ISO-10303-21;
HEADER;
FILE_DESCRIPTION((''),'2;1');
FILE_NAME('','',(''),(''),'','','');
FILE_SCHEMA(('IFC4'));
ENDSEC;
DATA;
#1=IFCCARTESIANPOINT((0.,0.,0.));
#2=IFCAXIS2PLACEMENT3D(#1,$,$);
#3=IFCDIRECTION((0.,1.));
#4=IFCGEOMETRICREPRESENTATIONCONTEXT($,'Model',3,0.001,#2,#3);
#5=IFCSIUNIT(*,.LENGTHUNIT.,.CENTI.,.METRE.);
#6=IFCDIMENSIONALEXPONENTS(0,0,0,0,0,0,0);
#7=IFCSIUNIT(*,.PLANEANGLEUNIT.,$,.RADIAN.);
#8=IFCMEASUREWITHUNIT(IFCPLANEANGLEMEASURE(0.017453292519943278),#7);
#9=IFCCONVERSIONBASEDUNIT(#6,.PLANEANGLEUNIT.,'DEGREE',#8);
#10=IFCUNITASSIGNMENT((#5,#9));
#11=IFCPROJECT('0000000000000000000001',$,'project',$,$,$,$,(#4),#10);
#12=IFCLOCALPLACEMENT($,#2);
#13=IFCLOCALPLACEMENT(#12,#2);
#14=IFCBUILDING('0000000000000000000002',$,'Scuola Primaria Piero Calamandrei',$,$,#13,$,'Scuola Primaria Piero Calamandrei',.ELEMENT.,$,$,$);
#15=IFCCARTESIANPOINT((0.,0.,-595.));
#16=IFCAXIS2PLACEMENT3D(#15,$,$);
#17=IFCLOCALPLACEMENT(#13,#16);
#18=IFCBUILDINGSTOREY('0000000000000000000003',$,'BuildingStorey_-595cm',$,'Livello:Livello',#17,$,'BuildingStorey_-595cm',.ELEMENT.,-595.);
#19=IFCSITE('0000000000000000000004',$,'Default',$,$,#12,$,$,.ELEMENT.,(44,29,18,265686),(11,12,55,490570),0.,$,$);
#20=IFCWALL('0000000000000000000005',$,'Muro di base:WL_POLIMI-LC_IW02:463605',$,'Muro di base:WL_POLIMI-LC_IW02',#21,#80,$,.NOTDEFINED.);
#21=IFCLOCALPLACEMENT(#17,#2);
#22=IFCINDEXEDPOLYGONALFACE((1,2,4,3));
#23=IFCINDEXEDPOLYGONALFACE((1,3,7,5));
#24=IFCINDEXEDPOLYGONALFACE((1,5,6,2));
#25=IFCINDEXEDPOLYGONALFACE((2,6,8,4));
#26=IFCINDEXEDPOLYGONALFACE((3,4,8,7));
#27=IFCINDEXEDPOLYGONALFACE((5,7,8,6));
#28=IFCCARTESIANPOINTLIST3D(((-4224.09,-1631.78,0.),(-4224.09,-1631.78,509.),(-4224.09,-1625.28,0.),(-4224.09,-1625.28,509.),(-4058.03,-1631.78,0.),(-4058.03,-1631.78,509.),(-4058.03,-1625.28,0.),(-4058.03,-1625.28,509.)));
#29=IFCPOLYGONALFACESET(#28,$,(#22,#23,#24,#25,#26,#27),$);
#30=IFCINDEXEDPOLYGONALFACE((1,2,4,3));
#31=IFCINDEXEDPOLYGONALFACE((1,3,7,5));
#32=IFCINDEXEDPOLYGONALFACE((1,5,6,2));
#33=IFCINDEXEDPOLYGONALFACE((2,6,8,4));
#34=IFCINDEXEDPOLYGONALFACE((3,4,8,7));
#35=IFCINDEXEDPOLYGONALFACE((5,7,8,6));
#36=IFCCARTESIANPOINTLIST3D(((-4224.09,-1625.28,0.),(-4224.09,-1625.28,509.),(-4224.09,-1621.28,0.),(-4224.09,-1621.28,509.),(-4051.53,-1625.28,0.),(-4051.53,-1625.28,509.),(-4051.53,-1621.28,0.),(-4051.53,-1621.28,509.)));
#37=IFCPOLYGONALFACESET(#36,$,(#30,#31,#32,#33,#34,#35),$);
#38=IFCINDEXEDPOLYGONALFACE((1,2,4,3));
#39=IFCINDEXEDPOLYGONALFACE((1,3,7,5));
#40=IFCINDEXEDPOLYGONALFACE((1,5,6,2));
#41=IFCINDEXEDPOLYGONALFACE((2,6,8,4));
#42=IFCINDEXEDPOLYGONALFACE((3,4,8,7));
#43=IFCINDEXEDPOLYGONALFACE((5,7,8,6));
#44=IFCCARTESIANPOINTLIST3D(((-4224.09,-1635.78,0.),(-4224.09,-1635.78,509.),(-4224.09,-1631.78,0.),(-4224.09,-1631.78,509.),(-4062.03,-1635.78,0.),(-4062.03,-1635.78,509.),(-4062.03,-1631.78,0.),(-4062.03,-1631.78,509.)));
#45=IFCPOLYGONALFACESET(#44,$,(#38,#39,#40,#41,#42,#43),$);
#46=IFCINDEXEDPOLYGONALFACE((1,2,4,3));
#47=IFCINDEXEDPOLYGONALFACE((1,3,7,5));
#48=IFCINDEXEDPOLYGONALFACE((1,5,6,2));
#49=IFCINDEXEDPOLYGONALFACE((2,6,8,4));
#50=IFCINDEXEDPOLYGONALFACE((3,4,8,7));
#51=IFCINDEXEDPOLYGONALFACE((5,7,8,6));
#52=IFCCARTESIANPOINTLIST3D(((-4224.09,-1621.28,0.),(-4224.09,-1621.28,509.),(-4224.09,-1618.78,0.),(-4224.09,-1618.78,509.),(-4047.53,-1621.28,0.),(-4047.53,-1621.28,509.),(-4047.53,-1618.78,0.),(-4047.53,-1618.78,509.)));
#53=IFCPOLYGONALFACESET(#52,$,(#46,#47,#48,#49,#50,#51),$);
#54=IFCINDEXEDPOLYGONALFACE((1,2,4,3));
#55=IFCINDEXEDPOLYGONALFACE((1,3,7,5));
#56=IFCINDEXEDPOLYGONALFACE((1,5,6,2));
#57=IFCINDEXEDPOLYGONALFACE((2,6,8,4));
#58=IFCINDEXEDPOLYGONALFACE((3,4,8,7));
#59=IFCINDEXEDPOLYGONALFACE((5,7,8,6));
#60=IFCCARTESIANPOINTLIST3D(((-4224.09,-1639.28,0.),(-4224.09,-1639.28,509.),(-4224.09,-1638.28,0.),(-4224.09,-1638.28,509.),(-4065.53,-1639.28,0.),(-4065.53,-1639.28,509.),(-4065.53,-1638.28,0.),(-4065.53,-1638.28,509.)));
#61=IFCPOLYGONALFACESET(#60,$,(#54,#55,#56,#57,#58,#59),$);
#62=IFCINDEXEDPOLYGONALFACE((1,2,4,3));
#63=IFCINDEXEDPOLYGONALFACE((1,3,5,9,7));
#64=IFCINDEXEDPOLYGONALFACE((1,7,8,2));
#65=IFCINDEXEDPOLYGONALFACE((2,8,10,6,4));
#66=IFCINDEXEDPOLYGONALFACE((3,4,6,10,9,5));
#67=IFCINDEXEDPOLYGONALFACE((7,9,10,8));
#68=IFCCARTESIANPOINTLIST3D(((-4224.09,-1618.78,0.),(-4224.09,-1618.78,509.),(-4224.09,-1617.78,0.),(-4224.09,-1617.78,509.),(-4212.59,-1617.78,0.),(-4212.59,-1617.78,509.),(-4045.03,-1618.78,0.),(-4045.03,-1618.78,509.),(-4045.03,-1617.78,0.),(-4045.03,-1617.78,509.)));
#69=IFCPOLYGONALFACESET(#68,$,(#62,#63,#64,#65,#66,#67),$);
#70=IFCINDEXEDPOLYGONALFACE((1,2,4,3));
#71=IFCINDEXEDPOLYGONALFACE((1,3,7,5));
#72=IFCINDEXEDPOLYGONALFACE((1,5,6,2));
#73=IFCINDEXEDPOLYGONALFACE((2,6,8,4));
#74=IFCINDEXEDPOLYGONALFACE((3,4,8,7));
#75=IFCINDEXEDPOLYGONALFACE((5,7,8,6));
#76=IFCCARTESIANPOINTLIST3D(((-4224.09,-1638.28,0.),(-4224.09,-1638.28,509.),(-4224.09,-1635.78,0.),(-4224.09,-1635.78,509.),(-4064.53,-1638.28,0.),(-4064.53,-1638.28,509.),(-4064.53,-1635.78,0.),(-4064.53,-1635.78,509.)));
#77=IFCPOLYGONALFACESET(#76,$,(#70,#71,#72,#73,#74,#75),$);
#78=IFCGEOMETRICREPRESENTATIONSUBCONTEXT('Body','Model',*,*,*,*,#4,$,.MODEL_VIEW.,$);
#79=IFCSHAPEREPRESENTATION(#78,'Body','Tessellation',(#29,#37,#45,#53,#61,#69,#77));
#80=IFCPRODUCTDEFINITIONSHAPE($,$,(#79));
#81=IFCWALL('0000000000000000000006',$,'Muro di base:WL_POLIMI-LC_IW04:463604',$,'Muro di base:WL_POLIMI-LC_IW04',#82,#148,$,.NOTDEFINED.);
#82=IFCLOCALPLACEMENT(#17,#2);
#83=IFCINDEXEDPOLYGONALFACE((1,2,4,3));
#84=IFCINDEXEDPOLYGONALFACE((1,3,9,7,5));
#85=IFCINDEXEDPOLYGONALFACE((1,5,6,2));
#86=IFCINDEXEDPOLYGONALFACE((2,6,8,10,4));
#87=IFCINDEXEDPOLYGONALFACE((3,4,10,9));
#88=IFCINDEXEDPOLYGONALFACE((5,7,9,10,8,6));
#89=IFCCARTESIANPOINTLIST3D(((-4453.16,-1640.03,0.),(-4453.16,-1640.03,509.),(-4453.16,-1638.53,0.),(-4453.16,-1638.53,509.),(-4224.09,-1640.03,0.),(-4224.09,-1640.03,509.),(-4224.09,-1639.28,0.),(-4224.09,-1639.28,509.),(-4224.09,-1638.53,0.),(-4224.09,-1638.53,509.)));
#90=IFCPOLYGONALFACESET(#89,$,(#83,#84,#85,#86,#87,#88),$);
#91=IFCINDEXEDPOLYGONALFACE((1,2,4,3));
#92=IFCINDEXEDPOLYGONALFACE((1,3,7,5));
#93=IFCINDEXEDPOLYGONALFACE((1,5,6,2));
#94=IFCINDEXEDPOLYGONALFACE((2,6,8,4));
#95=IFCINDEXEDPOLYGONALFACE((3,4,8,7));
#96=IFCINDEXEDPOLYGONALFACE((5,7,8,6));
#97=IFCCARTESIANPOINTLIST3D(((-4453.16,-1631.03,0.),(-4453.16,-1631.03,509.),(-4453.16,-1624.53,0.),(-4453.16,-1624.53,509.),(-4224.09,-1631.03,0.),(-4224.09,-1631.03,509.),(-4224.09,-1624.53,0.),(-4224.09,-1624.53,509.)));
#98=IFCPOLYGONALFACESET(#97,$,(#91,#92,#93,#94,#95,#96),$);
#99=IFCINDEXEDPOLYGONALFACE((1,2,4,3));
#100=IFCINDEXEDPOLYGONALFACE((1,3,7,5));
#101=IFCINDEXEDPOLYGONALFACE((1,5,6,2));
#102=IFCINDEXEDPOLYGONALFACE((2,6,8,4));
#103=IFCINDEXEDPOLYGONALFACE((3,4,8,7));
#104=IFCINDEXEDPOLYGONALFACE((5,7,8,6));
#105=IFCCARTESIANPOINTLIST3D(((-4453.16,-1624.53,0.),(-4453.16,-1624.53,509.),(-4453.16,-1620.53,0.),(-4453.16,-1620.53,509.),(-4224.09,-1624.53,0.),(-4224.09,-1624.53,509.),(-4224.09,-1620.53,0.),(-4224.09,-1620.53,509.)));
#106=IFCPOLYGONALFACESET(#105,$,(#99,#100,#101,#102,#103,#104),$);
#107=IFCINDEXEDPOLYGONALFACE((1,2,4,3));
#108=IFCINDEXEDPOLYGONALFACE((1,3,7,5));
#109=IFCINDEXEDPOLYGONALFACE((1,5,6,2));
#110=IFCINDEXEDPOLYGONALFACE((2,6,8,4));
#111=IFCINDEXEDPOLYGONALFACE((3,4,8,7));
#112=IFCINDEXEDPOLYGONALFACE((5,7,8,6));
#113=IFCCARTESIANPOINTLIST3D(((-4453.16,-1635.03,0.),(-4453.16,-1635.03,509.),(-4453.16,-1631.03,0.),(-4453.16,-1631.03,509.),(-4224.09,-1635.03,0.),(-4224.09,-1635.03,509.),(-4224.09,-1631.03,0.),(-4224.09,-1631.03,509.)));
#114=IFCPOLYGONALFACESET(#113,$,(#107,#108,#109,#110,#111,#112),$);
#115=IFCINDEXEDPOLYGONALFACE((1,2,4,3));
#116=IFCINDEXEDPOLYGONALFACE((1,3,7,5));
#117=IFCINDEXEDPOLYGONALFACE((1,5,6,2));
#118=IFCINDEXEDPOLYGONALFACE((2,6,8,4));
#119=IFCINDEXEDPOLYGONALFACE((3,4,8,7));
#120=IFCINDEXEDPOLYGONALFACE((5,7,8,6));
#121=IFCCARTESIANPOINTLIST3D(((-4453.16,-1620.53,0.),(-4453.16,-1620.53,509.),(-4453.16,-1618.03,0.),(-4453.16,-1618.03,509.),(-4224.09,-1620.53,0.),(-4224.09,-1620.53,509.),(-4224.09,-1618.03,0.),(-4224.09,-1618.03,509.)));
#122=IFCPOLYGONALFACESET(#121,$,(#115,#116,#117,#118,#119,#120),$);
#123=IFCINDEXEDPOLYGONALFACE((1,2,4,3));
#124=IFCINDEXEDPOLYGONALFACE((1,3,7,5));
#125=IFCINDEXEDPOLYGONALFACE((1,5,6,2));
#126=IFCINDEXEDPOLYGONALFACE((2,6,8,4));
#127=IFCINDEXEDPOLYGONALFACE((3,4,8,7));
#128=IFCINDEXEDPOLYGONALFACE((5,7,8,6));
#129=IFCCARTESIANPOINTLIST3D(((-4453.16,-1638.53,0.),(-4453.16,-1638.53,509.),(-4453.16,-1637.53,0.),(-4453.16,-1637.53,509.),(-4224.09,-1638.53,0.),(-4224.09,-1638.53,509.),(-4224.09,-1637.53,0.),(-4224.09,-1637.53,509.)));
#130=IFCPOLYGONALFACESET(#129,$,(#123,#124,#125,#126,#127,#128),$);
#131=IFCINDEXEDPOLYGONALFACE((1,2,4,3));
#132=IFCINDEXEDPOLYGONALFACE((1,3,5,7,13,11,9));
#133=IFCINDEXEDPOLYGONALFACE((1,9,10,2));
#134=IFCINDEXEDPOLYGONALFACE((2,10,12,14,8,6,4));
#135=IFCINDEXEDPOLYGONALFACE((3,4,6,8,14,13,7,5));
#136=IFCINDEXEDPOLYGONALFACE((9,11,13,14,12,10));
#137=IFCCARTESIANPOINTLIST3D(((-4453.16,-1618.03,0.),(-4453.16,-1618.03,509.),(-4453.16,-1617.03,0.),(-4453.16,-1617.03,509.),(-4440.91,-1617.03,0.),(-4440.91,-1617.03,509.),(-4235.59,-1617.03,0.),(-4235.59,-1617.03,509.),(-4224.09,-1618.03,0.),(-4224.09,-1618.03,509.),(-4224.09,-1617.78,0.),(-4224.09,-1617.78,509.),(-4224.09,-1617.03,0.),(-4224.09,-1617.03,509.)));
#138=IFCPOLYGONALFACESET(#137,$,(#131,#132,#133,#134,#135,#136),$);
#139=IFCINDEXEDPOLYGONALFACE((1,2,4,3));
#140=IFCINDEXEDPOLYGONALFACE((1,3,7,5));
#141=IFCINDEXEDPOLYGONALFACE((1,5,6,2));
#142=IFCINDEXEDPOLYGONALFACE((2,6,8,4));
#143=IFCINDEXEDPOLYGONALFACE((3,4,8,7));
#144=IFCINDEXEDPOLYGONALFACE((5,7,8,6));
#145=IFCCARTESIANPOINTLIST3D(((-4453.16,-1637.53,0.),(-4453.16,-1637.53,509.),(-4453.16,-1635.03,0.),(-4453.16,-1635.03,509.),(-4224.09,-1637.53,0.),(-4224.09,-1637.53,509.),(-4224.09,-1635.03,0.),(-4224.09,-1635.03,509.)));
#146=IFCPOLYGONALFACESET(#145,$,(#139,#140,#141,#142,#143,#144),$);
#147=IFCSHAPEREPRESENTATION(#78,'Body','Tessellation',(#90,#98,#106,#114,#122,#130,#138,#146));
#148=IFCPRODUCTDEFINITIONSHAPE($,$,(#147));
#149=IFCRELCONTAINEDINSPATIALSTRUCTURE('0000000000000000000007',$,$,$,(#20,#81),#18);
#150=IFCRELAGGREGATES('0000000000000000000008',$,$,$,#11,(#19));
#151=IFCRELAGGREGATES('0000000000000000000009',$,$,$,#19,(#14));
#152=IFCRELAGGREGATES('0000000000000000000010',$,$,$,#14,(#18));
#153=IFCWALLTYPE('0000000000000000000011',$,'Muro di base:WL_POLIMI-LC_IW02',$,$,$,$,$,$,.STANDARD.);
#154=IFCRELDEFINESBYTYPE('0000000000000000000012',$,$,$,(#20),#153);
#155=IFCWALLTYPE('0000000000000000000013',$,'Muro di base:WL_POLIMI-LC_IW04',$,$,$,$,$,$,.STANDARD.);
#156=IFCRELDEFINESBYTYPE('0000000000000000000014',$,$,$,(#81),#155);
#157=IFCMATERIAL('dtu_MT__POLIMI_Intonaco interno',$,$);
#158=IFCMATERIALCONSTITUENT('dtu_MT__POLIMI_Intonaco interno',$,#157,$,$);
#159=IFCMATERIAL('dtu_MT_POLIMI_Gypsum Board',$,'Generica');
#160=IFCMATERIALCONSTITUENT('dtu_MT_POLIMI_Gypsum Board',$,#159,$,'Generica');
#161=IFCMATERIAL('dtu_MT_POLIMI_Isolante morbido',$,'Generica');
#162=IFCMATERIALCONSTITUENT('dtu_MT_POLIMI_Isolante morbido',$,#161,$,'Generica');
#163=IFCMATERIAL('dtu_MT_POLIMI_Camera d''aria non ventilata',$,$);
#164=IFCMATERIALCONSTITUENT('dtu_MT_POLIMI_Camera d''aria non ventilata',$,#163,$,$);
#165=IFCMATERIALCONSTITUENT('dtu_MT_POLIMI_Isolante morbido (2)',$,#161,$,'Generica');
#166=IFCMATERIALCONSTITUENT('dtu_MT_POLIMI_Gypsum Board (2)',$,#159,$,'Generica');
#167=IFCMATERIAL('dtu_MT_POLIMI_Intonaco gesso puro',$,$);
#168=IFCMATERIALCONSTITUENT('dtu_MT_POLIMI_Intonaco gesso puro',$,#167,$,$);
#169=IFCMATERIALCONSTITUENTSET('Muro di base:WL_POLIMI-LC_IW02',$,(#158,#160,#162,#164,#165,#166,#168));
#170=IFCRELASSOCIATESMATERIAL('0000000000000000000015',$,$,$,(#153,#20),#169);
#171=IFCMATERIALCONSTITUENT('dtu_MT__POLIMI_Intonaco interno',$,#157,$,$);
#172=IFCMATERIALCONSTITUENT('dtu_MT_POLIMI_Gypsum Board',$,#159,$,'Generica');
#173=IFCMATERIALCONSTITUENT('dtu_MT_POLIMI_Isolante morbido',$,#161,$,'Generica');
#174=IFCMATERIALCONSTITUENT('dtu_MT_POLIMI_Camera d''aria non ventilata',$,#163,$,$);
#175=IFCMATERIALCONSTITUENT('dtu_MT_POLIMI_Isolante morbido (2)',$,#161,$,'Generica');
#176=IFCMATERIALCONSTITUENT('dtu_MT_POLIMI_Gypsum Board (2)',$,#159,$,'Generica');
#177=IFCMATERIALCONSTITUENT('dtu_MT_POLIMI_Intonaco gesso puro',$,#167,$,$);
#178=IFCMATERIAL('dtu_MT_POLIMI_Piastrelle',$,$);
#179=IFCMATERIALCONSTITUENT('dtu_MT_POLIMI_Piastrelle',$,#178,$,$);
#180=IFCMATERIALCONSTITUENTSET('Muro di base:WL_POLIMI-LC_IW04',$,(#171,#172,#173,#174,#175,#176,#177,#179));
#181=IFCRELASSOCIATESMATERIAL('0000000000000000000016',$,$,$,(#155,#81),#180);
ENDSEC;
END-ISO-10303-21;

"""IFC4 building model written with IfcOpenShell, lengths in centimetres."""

from ifc_helpers import new_model, entity, si_unit, converted_unit, direction, frame, origin, place, context, subcontext, project, spatial, indexed_curve, outline, extrude, material, constituent, constituent_set, type_object, element, save


model = new_model("IFC4")

# Units and contexts
model_context = context("Model", 3, precision=0.001, world=origin(), true_north=direction((0.0, 1.0)))
body_context = subcontext(model_context, "Body", "Model", "MODEL_VIEW")
ifc_project = project(units=[si_unit("LENGTHUNIT", "METRE", prefix="CENTI"), converted_unit("PLANEANGLEUNIT", "DEGREE", entity("IfcPlaneAngleMeasure", 0.017453292519943278), si_unit("PLANEANGLEUNIT", "RADIAN"), dimensions=[0, 0, 0, 0, 0, 0, 0])], contexts=[model_context])

# Site, building, storey
site_placement = place(None, origin())
site = spatial("IfcSite", under=ifc_project, at=site_placement, Name="Default", CompositionType="ELEMENT", RefLatitude=(44, 29, 18, 265686), RefLongitude=(11, 12, 55, 490570), RefElevation=0.0)
building_placement = place(site_placement, origin())
building = spatial("IfcBuilding", under=site, at=building_placement, Name="Scuola Primaria Piero Calamandrei", LongName="Scuola Primaria Piero Calamandrei", CompositionType="ELEMENT")
storey_placement = place(building_placement, frame((0.0, 0.0, -595.0)))
storey = spatial("IfcBuildingStorey", under=building, at=storey_placement, Name="BuildingStorey_-595cm", ObjectType="Livello:Livello", LongName="BuildingStorey_-595cm", CompositionType="ELEMENT", Elevation=-595.0)

# Shared definitions
ifc_material_1 = material(Name="dtu_MT__POLIMI_Intonaco interno")

# Shared definitions
ifc_constituent_1 = constituent(ifc_material_1, Name="dtu_MT__POLIMI_Intonaco interno")
ifc_material_2 = material(Name="dtu_MT_POLIMI_Gypsum Board", Category="Generica")
ifc_constituent_2 = constituent(ifc_material_2, Name="dtu_MT_POLIMI_Gypsum Board", Category="Generica")
ifc_material_3 = material(Name="dtu_MT_POLIMI_Isolante morbido", Category="Generica")
ifc_constituent_3 = constituent(ifc_material_3, Name="dtu_MT_POLIMI_Isolante morbido", Category="Generica")
ifc_material_4 = material(Name="dtu_MT_POLIMI_Camera d'aria non ventilata")
ifc_constituent_4 = constituent(ifc_material_4, Name="dtu_MT_POLIMI_Camera d'aria non ventilata")
ifc_constituent_5 = constituent(ifc_material_3, Name="dtu_MT_POLIMI_Isolante morbido (2)", Category="Generica")
ifc_constituent_6 = constituent(ifc_material_2, Name="dtu_MT_POLIMI_Gypsum Board (2)", Category="Generica")
ifc_material_5 = material(Name="dtu_MT_POLIMI_Intonaco gesso puro")
ifc_constituent_7 = constituent(ifc_material_5, Name="dtu_MT_POLIMI_Intonaco gesso puro")
ifc_constituent_set_1 = constituent_set(constituents=[ifc_constituent_1, ifc_constituent_2, ifc_constituent_3, ifc_constituent_4, ifc_constituent_5, ifc_constituent_6, ifc_constituent_7], Name="Muro di base:WL_POLIMI-LC_IW02")
wall_type_1 = type_object("IfcWallType", Name="Muro di base:WL_POLIMI-LC_IW02", PredefinedType="STANDARD", material=ifc_constituent_set_1)

# Wall
wall_1_placement = place(storey_placement, frame((-4224.09, -1628.53, 0.0)))
element("IfcWall", 1, at=wall_1_placement, inside=storey, type_object=wall_type_1, material=ifc_constituent_set_1, Name="Muro di base:WL_POLIMI-LC_IW02:463605", ObjectType="Muro di base:WL_POLIMI-LC_IW02", PredefinedType="NOTDEFINED", context=body_context, shape_type="SweptSolid", body=[
    extrude(outline(indexed_curve([(-83.03, -3.25), (83.03, -3.25), (83.03, 3.25), (-83.03, 3.25), (-83.03, -3.25)], self_intersect=False)), frame((83.03, 0.0, 0.0)), (0.0, 0.0, 1.0), 509.0),
    extrude(outline(indexed_curve([(-86.28, -2.0), (86.28, -2.0), (86.28, 2.0), (-86.28, 2.0), (-86.28, -2.0)], self_intersect=False)), frame((86.28, 5.25, 0.0)), (0.0, 0.0, 1.0), 509.0),
    extrude(outline(indexed_curve([(-81.03, -2.0), (81.03, -2.0), (81.03, 2.0), (-81.03, 2.0), (-81.03, -2.0)], self_intersect=False)), frame((81.03, -5.25, 0.0)), (0.0, 0.0, 1.0), 509.0),
    extrude(outline(indexed_curve([(-88.28, -1.25), (88.28, -1.25), (88.28, 1.25), (-88.28, 1.25), (-88.28, -1.25)], self_intersect=False)), frame((88.28, 8.5, 0.0)), (0.0, 0.0, 1.0), 509.0),
    extrude(outline(indexed_curve([(-0.5, -79.28), (0.5, -79.28), (0.5, 79.28), (-0.5, 79.28), (-0.5, -79.28)], self_intersect=False)), frame((79.28, -10.25, 0.0), z_axis=(0.0, 0.0, 1.0), x_axis=(0.0, 1.0, 0.0)), (0.0, 0.0, 1.0), 509.0),
    extrude(outline(indexed_curve([(62.43, -0.4), (73.93, -0.4), (73.93, 0.6), (-105.14, 0.6), (-105.14, -0.4), (62.43, -0.4)], self_intersect=False)), frame((73.93, 10.35, 0.0), z_axis=(0.0, 0.0, 1.0), x_axis=(-1.0, 0.0, 0.0)), (0.0, 0.0, 1.0), 509.0),
    extrude(outline(indexed_curve([(-79.78, -1.25), (79.78, -1.25), (79.78, 1.25), (-79.78, 1.25), (-79.78, -1.25)], self_intersect=False)), frame((79.78, -8.5, 0.0)), (0.0, 0.0, 1.0), 509.0),
])

# Shared definitions
ifc_constituent_8 = constituent(ifc_material_1, Name="dtu_MT__POLIMI_Intonaco interno")
ifc_constituent_9 = constituent(ifc_material_2, Name="dtu_MT_POLIMI_Gypsum Board", Category="Generica")
ifc_constituent_10 = constituent(ifc_material_3, Name="dtu_MT_POLIMI_Isolante morbido", Category="Generica")
ifc_constituent_11 = constituent(ifc_material_4, Name="dtu_MT_POLIMI_Camera d'aria non ventilata")
ifc_constituent_12 = constituent(ifc_material_3, Name="dtu_MT_POLIMI_Isolante morbido (2)", Category="Generica")
ifc_constituent_13 = constituent(ifc_material_2, Name="dtu_MT_POLIMI_Gypsum Board (2)", Category="Generica")
ifc_constituent_14 = constituent(ifc_material_5, Name="dtu_MT_POLIMI_Intonaco gesso puro")
ifc_material_6 = material(Name="dtu_MT_POLIMI_Piastrelle")
ifc_constituent_15 = constituent(ifc_material_6, Name="dtu_MT_POLIMI_Piastrelle")
ifc_constituent_set_2 = constituent_set(constituents=[ifc_constituent_8, ifc_constituent_9, ifc_constituent_10, ifc_constituent_11, ifc_constituent_12, ifc_constituent_13, ifc_constituent_14, ifc_constituent_15], Name="Muro di base:WL_POLIMI-LC_IW04")
wall_type_2 = type_object("IfcWallType", Name="Muro di base:WL_POLIMI-LC_IW04", PredefinedType="STANDARD", material=ifc_constituent_set_2)

# Wall
wall_2_placement = place(storey_placement, frame((-4453.16, -1628.53, 0.0)))
element("IfcWall", 2, at=wall_2_placement, inside=storey, type_object=wall_type_2, material=ifc_constituent_set_2, Name="Muro di base:WL_POLIMI-LC_IW04:463604", ObjectType="Muro di base:WL_POLIMI-LC_IW04", PredefinedType="NOTDEFINED", context=body_context, shape_type="SweptSolid", body=[
    extrude(outline(indexed_curve([(-0.75, -91.63), (0.0, -91.63), (0.75, -91.63), (0.75, 137.44), (-0.75, 137.44), (-0.75, -91.63)], self_intersect=False)), frame((137.44, -10.75, 0.0), z_axis=(0.0, 0.0, 1.0), x_axis=(0.0, 1.0, 0.0)), (0.0, 0.0, 1.0), 509.0),
    extrude(outline(indexed_curve([(-114.54, -3.25), (114.54, -3.25), (114.54, 3.25), (-114.54, 3.25), (-114.54, -3.25)], self_intersect=False)), frame((114.54, 0.75, 0.0)), (0.0, 0.0, 1.0), 509.0),
    extrude(outline(indexed_curve([(-114.54, -2.0), (114.54, -2.0), (114.54, 2.0), (-114.54, 2.0), (-114.54, -2.0)], self_intersect=False)), frame((114.54, 6.0, 0.0)), (0.0, 0.0, 1.0), 509.0),
    extrude(outline(indexed_curve([(-114.54, -2.0), (114.54, -2.0), (114.54, 2.0), (-114.54, 2.0), (-114.54, -2.0)], self_intersect=False)), frame((114.54, -4.5, 0.0)), (0.0, 0.0, 1.0), 509.0),
    extrude(outline(indexed_curve([(-114.54, -1.25), (114.54, -1.25), (114.54, 1.25), (-114.54, 1.25), (-114.54, -1.25)], self_intersect=False)), frame((114.54, 9.25, 0.0)), (0.0, 0.0, 1.0), 509.0),
    extrude(outline(indexed_curve([(-114.54, -0.5), (114.54, -0.5), (114.54, 0.5), (-114.54, 0.5), (-114.54, -0.5)], self_intersect=False)), frame((114.54, -9.5, 0.0)), (0.0, 0.0, 1.0), 509.0),
    extrude(outline(indexed_curve([(-86.57, -0.39), (118.75, -0.39), (131.0, -0.39), (131.0, 0.61), (-98.07, 0.61), (-98.07, 0.36), (-98.07, -0.39), (-86.57, -0.39)], self_intersect=False)), frame((131.0, 11.11, 0.0), z_axis=(0.0, 0.0, 1.0), x_axis=(-1.0, 0.0, 0.0)), (0.0, 0.0, 1.0), 509.0),
    extrude(outline(indexed_curve([(-114.54, -1.25), (114.54, -1.25), (114.54, 1.25), (-114.54, 1.25), (-114.54, -1.25)], self_intersect=False)), frame((114.54, -7.75, 0.0)), (0.0, 0.0, 1.0), 509.0),
])

save(model, "model.ifc")
